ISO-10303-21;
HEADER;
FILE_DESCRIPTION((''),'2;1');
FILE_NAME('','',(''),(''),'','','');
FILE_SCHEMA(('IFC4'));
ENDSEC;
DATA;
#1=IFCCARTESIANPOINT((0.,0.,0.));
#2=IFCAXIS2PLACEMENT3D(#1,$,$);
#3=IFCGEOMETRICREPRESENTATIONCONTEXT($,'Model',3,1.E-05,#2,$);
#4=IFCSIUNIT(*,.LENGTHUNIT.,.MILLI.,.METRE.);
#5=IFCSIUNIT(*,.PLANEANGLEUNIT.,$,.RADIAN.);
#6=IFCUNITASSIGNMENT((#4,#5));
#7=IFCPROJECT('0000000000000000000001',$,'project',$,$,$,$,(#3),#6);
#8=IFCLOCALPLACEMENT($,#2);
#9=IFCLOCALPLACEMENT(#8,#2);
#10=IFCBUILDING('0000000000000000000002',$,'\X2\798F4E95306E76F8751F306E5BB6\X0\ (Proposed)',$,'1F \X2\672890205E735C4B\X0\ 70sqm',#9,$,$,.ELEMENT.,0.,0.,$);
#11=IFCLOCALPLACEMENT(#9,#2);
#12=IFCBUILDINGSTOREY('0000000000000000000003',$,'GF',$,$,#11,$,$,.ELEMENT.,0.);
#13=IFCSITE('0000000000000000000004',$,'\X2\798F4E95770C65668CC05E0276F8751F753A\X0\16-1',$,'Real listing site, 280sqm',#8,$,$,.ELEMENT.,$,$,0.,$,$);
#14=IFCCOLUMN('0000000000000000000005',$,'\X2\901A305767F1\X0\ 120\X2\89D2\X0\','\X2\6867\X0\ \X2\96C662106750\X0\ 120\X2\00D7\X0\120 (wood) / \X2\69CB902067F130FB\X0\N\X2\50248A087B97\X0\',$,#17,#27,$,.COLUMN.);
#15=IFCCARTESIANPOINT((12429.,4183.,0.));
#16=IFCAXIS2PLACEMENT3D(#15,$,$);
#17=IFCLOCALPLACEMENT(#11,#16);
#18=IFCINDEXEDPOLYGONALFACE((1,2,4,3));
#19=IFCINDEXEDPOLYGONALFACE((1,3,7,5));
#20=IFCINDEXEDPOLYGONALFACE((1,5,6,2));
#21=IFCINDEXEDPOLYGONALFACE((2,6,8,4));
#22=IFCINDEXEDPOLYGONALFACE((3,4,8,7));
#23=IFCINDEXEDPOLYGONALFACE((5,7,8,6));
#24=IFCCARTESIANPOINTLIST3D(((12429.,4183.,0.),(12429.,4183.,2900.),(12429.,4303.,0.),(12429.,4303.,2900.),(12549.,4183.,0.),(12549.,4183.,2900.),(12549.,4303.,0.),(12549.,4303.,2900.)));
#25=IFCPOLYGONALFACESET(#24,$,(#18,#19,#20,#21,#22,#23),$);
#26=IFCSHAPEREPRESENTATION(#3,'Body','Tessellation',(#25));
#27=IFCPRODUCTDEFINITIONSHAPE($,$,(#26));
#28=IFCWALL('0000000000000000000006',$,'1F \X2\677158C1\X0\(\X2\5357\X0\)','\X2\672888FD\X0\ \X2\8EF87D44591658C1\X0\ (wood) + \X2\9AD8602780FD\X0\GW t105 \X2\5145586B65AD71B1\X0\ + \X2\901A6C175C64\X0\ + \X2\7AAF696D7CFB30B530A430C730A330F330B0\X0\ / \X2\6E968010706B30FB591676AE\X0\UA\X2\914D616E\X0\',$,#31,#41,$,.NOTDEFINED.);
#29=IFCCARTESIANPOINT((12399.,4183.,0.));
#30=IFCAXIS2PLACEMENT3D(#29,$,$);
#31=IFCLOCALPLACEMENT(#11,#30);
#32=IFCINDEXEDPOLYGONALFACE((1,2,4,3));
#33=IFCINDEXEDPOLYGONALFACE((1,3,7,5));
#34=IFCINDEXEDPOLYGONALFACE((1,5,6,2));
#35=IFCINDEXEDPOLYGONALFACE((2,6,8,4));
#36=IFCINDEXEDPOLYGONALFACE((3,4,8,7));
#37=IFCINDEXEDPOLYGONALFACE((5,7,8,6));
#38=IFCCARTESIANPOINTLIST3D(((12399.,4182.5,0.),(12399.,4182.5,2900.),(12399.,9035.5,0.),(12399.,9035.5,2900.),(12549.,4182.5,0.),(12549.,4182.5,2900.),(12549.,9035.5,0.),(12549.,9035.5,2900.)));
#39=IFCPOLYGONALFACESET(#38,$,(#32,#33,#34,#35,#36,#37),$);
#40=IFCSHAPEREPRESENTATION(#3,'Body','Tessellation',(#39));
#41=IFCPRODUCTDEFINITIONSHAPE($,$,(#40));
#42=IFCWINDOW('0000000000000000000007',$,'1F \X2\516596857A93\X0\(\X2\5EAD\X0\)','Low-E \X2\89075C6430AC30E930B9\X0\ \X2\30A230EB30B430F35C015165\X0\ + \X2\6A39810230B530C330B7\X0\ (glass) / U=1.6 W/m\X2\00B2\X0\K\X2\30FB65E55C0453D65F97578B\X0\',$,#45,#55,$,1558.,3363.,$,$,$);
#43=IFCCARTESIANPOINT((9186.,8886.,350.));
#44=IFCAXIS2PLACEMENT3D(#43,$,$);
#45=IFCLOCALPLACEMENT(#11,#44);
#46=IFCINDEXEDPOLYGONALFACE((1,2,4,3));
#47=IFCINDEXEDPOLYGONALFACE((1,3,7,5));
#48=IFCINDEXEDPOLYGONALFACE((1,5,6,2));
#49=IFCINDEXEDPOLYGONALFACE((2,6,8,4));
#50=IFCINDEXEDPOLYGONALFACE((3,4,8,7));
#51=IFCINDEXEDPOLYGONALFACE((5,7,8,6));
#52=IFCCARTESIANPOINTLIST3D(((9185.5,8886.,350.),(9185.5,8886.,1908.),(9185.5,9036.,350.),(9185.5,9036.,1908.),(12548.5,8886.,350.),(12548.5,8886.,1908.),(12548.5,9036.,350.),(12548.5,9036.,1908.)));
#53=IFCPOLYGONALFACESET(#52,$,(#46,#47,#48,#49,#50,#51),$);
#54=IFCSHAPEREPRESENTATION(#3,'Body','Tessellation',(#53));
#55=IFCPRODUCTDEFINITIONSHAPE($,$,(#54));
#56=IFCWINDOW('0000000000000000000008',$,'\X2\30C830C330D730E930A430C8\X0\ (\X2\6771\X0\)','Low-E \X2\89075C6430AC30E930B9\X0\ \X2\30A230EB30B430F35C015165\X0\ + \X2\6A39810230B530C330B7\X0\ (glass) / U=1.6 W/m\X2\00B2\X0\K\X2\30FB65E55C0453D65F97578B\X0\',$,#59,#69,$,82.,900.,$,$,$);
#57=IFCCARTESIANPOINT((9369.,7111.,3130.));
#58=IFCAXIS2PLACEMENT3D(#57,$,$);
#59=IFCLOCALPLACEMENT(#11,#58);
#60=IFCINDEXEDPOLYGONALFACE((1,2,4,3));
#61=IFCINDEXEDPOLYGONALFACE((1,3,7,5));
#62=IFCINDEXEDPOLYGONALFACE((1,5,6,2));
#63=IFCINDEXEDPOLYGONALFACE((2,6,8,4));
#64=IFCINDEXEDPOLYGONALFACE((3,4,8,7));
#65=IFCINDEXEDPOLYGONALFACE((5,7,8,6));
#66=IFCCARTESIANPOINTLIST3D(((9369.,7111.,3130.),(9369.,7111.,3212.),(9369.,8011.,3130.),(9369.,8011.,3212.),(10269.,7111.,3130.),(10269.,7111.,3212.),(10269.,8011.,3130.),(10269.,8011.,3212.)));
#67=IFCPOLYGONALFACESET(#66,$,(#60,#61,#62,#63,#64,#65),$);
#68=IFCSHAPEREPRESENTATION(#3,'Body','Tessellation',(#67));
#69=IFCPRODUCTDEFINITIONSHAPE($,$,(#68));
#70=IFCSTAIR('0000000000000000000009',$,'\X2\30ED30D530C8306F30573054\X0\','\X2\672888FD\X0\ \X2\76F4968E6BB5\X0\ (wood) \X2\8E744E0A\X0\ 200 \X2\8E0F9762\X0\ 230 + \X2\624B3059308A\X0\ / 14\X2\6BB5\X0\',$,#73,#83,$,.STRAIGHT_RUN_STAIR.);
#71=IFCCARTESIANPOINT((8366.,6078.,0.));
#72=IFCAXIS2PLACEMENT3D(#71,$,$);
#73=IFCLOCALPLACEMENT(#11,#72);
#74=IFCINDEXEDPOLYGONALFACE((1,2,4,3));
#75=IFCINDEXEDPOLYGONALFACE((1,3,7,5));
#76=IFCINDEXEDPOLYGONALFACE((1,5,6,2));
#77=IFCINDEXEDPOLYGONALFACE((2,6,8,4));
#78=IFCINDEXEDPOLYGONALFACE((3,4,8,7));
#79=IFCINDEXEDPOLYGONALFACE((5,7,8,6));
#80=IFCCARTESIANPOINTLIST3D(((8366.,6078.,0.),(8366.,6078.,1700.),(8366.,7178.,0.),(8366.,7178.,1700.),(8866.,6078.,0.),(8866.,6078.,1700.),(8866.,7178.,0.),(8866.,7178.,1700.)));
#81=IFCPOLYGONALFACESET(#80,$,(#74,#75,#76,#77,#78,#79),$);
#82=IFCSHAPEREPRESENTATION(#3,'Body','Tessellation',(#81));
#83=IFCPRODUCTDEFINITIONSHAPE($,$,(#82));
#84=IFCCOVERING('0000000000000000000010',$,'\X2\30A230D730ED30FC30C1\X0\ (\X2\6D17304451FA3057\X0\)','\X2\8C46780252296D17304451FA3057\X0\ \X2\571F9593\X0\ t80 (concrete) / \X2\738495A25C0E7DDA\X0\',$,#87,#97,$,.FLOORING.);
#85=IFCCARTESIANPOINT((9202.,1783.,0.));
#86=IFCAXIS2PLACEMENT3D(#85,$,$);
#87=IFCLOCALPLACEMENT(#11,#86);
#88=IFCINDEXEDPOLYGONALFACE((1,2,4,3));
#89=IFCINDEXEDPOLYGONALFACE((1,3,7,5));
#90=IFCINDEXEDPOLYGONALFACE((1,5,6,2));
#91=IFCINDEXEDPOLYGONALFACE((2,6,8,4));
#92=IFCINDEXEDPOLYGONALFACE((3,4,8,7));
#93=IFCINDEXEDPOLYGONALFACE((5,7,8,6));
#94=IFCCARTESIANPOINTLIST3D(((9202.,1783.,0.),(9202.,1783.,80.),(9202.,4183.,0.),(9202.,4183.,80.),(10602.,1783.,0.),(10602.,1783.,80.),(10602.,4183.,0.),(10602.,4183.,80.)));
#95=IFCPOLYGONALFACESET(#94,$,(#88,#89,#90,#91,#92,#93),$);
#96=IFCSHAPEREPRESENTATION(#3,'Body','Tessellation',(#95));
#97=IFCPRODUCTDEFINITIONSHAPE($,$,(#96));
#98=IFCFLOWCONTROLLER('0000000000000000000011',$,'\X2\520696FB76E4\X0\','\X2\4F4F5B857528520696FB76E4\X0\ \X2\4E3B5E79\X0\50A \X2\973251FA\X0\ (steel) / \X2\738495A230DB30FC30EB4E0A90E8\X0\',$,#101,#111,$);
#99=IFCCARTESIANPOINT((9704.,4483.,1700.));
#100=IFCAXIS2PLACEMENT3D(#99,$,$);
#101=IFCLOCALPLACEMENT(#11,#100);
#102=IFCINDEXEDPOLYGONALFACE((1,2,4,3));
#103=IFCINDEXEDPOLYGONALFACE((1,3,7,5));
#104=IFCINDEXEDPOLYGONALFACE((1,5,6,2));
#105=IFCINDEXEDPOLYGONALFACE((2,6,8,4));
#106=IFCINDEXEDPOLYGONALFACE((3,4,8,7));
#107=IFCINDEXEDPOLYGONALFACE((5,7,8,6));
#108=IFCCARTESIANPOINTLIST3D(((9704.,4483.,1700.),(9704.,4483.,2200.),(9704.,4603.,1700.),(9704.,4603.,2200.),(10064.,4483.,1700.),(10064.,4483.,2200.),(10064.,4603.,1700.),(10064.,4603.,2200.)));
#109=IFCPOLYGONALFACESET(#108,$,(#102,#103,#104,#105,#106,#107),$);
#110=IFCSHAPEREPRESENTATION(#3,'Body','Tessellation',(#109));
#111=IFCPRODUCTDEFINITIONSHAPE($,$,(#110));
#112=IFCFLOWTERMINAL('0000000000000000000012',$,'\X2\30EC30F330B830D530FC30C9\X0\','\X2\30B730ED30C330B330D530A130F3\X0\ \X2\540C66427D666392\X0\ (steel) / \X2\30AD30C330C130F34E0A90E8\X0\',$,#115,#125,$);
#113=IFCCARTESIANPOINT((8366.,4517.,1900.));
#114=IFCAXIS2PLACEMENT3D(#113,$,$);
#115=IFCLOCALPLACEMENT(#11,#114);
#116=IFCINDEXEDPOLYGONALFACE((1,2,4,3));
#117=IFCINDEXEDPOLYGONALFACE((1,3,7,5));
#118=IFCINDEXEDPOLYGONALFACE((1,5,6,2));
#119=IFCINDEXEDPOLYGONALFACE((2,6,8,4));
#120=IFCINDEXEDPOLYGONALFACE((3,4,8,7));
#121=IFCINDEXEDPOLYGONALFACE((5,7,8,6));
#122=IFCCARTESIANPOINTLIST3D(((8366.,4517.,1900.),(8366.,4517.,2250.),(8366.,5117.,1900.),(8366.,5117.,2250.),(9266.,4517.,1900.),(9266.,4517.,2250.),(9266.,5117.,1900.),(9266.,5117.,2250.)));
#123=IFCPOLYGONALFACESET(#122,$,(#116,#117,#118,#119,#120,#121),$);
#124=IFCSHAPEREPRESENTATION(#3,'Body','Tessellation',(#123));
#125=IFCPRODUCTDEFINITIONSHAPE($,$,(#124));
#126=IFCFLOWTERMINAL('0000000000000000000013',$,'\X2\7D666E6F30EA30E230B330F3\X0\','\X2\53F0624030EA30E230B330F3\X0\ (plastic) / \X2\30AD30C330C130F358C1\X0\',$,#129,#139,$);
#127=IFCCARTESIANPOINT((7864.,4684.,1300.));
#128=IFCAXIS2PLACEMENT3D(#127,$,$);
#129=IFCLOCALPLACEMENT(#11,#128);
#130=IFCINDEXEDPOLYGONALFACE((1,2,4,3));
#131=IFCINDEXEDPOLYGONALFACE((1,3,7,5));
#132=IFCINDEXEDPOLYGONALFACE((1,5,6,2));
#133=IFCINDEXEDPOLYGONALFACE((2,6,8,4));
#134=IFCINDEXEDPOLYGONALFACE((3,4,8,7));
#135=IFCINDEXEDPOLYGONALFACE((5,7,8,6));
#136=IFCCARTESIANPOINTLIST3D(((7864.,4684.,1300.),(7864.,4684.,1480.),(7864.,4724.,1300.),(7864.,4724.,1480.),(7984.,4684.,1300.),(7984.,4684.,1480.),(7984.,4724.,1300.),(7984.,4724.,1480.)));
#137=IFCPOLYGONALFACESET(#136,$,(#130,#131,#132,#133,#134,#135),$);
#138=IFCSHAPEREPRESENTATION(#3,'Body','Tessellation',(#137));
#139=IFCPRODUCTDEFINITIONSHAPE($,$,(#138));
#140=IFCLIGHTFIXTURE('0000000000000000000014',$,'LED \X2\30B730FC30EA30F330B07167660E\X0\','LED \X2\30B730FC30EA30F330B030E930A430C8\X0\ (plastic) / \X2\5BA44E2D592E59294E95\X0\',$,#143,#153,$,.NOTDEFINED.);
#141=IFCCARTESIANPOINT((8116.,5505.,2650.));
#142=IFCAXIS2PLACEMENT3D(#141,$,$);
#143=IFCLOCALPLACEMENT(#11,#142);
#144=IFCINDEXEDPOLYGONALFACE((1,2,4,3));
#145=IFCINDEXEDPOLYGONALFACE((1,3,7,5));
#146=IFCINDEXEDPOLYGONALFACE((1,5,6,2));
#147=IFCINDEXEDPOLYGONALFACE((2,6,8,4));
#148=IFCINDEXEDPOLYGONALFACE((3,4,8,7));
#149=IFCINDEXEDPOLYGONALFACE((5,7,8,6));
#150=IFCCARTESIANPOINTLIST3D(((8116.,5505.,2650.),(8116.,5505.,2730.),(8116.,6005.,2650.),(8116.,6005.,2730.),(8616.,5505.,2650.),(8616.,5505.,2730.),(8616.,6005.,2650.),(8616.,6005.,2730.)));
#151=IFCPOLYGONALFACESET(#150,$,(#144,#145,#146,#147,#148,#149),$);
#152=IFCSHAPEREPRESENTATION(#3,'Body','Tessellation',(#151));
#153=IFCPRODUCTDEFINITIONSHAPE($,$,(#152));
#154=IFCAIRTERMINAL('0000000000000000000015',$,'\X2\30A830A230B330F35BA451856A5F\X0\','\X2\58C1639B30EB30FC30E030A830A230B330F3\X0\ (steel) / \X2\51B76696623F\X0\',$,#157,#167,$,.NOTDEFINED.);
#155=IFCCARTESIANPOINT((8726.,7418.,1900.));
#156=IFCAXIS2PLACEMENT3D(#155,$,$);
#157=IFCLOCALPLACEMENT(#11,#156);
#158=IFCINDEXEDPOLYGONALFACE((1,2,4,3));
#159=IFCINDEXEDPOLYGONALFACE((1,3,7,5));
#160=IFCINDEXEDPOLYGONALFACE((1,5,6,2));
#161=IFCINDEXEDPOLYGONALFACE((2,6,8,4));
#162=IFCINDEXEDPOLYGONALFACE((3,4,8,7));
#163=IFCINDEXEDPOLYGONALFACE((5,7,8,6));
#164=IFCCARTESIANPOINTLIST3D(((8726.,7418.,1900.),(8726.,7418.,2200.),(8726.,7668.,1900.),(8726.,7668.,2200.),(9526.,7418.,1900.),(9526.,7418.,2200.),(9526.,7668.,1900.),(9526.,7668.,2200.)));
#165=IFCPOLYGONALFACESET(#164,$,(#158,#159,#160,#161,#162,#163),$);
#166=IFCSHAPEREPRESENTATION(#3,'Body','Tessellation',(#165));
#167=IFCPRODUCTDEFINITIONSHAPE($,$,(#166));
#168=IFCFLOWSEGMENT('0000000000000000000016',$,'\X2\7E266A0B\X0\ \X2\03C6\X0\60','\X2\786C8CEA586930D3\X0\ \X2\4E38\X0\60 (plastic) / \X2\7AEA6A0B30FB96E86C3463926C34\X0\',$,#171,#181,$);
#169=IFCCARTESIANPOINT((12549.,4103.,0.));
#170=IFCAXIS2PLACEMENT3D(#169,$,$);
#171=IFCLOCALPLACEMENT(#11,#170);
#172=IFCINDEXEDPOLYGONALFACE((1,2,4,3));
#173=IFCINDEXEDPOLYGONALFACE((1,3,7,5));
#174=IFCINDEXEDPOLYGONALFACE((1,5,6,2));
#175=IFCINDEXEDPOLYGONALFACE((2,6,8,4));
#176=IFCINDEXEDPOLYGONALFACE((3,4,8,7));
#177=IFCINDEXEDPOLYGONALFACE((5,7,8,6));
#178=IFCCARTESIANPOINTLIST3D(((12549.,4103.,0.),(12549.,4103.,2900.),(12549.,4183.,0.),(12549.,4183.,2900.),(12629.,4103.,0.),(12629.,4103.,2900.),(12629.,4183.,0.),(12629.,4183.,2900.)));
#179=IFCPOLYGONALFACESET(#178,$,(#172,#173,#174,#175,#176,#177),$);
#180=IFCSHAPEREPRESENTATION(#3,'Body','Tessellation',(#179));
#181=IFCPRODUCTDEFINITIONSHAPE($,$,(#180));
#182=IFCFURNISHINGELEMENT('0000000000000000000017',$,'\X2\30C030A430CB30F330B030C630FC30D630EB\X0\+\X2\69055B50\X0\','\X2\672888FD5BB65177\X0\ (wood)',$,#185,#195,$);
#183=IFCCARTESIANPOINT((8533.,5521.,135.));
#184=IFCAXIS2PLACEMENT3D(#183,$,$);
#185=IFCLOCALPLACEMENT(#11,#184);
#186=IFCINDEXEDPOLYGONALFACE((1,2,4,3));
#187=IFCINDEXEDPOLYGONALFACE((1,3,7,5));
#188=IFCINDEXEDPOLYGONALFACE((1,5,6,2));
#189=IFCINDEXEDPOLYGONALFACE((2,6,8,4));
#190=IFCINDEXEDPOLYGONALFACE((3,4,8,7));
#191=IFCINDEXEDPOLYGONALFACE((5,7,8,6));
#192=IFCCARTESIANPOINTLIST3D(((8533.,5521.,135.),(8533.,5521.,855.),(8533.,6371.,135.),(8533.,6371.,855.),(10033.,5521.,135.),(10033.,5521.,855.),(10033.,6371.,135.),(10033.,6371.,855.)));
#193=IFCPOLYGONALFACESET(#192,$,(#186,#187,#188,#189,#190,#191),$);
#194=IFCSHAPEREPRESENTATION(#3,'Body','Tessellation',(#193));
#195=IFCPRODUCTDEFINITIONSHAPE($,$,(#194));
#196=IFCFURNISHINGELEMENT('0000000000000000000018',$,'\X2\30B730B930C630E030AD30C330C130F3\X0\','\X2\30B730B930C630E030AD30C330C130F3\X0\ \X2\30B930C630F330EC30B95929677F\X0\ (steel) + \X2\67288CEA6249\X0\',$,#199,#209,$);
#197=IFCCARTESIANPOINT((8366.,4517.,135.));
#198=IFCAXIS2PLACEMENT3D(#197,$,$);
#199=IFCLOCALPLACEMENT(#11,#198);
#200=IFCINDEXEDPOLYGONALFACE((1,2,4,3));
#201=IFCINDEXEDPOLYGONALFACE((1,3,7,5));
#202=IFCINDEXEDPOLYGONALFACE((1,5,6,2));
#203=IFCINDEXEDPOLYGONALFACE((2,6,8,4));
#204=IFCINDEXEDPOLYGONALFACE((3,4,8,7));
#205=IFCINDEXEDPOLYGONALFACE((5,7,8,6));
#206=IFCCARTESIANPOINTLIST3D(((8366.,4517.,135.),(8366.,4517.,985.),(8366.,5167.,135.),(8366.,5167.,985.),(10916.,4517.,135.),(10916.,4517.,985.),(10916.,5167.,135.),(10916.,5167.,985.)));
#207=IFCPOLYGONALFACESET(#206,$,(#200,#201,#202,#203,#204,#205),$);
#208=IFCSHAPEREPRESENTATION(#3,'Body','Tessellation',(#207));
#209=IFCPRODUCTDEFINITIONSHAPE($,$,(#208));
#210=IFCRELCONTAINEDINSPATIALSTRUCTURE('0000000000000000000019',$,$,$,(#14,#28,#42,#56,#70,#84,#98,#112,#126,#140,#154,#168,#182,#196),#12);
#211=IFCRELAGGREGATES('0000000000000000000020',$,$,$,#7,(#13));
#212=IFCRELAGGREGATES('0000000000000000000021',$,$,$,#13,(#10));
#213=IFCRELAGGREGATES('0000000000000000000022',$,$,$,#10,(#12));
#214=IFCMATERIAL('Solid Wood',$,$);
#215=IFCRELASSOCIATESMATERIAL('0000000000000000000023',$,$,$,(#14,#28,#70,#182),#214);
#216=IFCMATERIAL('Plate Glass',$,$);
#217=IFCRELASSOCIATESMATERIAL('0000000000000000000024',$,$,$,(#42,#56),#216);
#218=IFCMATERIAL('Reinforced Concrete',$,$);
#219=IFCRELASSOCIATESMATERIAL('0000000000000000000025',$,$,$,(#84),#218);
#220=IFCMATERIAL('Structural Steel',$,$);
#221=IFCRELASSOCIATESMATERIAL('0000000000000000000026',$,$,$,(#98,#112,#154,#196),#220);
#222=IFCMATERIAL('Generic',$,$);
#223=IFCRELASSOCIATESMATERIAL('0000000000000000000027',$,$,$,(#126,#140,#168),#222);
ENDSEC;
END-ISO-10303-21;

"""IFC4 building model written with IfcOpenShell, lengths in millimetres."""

from ifc_helpers import new_model, si_unit, frame, frame_2d, origin, place, context, project, spatial, rectangle, extrude, material, element, fill, save


model = new_model("IFC4")

# Units and contexts
model_context = context("Model", 3, precision=1e-05, world=origin())
ifc_project = project(units=[si_unit("LENGTHUNIT", "METRE", prefix="MILLI"), si_unit("PLANEANGLEUNIT", "RADIAN")], contexts=[model_context])

# Site, building, storey
site_placement = place(None, origin())
site = spatial("IfcSite", under=ifc_project, at=site_placement, Name="福井県敦賀市相生町16-1", ObjectType="Real listing site, 280sqm", CompositionType="ELEMENT", RefElevation=0.0)
building_placement = place(site_placement, origin())
building = spatial("IfcBuilding", under=site, at=building_placement, Name="福井の相生の家 (Proposed)", ObjectType="1F 木造平屋 70sqm", CompositionType="ELEMENT", ElevationOfRefHeight=0.0, ElevationOfTerrain=0.0)
storey_placement = place(building_placement, origin())
storey = spatial("IfcBuildingStorey", under=building, at=storey_placement, Name="GF", CompositionType="ELEMENT", Elevation=0.0)

# Column
ifc_material_1 = material(Name="Solid Wood")
column_1_placement = place(storey_placement, frame((12429.0, 4183.0, 0.0)))
element("IfcColumn", 1, at=column_1_placement, inside=storey, material=ifc_material_1, Name="通し柱 120角", Description="桧 集成材 120×120 (wood) / 構造柱・N値計算", PredefinedType="COLUMN", context=model_context, shape_type="SweptSolid", body=[
    extrude(rectangle(XDim=120.0, YDim=120.0, at=frame_2d((60.0, 60.0))), frame((12429.0, 4183.0, 0.0)), (0.0, 0.0, 1.0), 2900.0),
])

# Wall, opening, window
wall_1_placement = place(storey_placement, frame((12399.0, 4183.0, 0.0)))
wall_1 = element("IfcWall", 2, at=wall_1_placement, inside=storey, material=ifc_material_1, Name="1F 東壁(南)", Description="木製 軸組外壁 (wood) + 高性能GW t105 充填断熱 + 通気層 + 窯業系サイディング / 準耐火・外皮UA配慮", PredefinedType="NOTDEFINED", context=model_context, shape_type="SweptSolid", body=[
    extrude(rectangle(XDim=150.0, YDim=4853.0, at=frame_2d((75.0, 2426.0))), frame((12399.0, 4183.0, 0.0)), (0.0, 0.0, 1.0), 2900.0),
])
opening_1_placement = place(storey_placement, frame((9186.0, 8886.0, 350.0)))
opening_1 = element("IfcOpeningElement", 3, at=opening_1_placement, cuts=wall_1, PredefinedType="NOTDEFINED", context=model_context, shape_type="SweptSolid", body=[
    extrude(rectangle(XDim=3363.0, YDim=150.0, at=frame_2d((1681.0, 75.0))), frame((9186.0, 8886.0, 350.0)), (0.0, 0.0, 1.0), 1558.0),
])
ifc_material_2 = material(Name="Plate Glass")
window_1_placement = place(storey_placement, frame((9186.0, 8886.0, 350.0)))
window_1 = element("IfcWindow", 4, at=window_1_placement, inside=storey, material=ifc_material_2, Name="1F 入隅窓(庭)", Description="Low-E 複層ガラス アルゴン封入 + 樹脂サッシ (glass) / U=1.6 W/m²K・日射取得型", OverallHeight=1558.0, OverallWidth=3363.0, context=model_context, shape_type="SweptSolid", body=[
    extrude(rectangle(XDim=3363.0, YDim=150.0, at=frame_2d((1681.0, 75.0))), frame((9186.0, 8886.0, 350.0)), (0.0, 0.0, 1.0), 1558.0),
])
fill(opening_1, window_1)

# Window
window_2_placement = place(storey_placement, frame((9369.0, 7111.0, 3130.0)))
element("IfcWindow", 5, at=window_2_placement, inside=storey, material=ifc_material_2, Name="トップライト (東)", Description="Low-E 複層ガラス アルゴン封入 + 樹脂サッシ (glass) / U=1.6 W/m²K・日射取得型", OverallHeight=82.0, OverallWidth=900.0, context=model_context, shape_type="SweptSolid", body=[
    extrude(rectangle(XDim=900.0, YDim=900.0, at=frame_2d((450.0, 450.0))), frame((9369.0, 7111.0, 3130.0)), (0.0, 0.0, 1.0), 82.0),
])

# Stair
stair_placement = place(storey_placement, frame((8366.0, 6078.0, 0.0)))
element("IfcStair", 6, at=stair_placement, inside=storey, material=ifc_material_1, Name="ロフトはしご", Description="木製 直階段 (wood) 蹴上 200 踏面 230 + 手すり / 14段", PredefinedType="STRAIGHT_RUN_STAIR", context=model_context, shape_type="SweptSolid", body=[
    extrude(rectangle(XDim=500.0, YDim=1100.0, at=frame_2d((250.0, 550.0))), frame((8366.0, 6078.0, 0.0)), (0.0, 0.0, 1.0), 1700.0),
])

# Covering
ifc_material_3 = material(Name="Reinforced Concrete")
covering_placement = place(storey_placement, frame((9202.0, 1783.0, 0.0)))
element("IfcCovering", 7, at=covering_placement, inside=storey, material=ifc_material_3, Name="アプローチ (洗い出し)", Description="豆砂利洗い出し 土間 t80 (concrete) / 玄関導線", PredefinedType="FLOORING", context=model_context, shape_type="SweptSolid", body=[
    extrude(rectangle(XDim=1400.0, YDim=2400.0, at=frame_2d((700.0, 1200.0))), frame((9202.0, 1783.0, 0.0)), (0.0, 0.0, 1.0), 80.0),
])

# Flow controller
ifc_material_4 = material(Name="Structural Steel")
flow_controller_placement = place(storey_placement, frame((9704.0, 4483.0, 1700.0)))
element("IfcFlowController", 8, at=flow_controller_placement, inside=storey, material=ifc_material_4, Name="分電盤", Description="住宅用分電盤 主幹50A 露出 (steel) / 玄関ホール上部", context=model_context, shape_type="SweptSolid", body=[
    extrude(rectangle(XDim=360.0, YDim=120.0, at=frame_2d((180.0, 60.0))), frame((9704.0, 4483.0, 1700.0)), (0.0, 0.0, 1.0), 500.0),
])

# Flow terminals
flow_terminal_1_placement = place(storey_placement, frame((8366.0, 4517.0, 1900.0)))
element("IfcFlowTerminal", 9, at=flow_terminal_1_placement, inside=storey, material=ifc_material_4, Name="レンジフード", Description="シロッコファン 同時給排 (steel) / キッチン上部", context=model_context, shape_type="SweptSolid", body=[
    extrude(rectangle(XDim=900.0, YDim=600.0, at=frame_2d((450.0, 300.0))), frame((8366.0, 4517.0, 1900.0)), (0.0, 0.0, 1.0), 350.0),
])
ifc_material_5 = material(Name="Generic")
flow_terminal_2_placement = place(storey_placement, frame((7864.0, 4684.0, 1300.0)))
element("IfcFlowTerminal", 10, at=flow_terminal_2_placement, inside=storey, material=ifc_material_5, Name="給湯リモコン", Description="台所リモコン (plastic) / キッチン壁", context=model_context, shape_type="SweptSolid", body=[
    extrude(rectangle(XDim=120.0, YDim=40.0, at=frame_2d((60.0, 20.0))), frame((7864.0, 4684.0, 1300.0)), (0.0, 0.0, 1.0), 180.0),
])

# Light fixture
light_fixture_placement = place(storey_placement, frame((8116.0, 5505.0, 2650.0)))
element("IfcLightFixture", 11, at=light_fixture_placement, inside=storey, material=ifc_material_5, Name="LED シーリング照明", Description="LED シーリングライト (plastic) / 室中央天井", PredefinedType="NOTDEFINED", context=model_context, shape_type="SweptSolid", body=[
    extrude(rectangle(XDim=500.0, YDim=500.0, at=frame_2d((250.0, 250.0))), frame((8116.0, 5505.0, 2650.0)), (0.0, 0.0, 1.0), 80.0),
])

# Air terminal
air_terminal_placement = place(storey_placement, frame((8726.0, 7418.0, 1900.0)))
element("IfcAirTerminal", 12, at=air_terminal_placement, inside=storey, material=ifc_material_4, Name="エアコン室内機", Description="壁掛ルームエアコン (steel) / 冷暖房", PredefinedType="NOTDEFINED", context=model_context, shape_type="SweptSolid", body=[
    extrude(rectangle(XDim=800.0, YDim=250.0, at=frame_2d((400.0, 125.0))), frame((8726.0, 7418.0, 1900.0)), (0.0, 0.0, 1.0), 300.0),
])

# Flow segment
flow_segment_placement = place(storey_placement, frame((12549.0, 4103.0, 0.0)))
element("IfcFlowSegment", 13, at=flow_segment_placement, inside=storey, material=ifc_material_5, Name="縦樋 φ60", Description="硬質塩ビ 丸60 (plastic) / 竪樋・雨水排水", context=model_context, shape_type="SweptSolid", body=[
    extrude(rectangle(XDim=80.0, YDim=80.0, at=frame_2d((40.0, 40.0))), frame((12549.0, 4103.0, 0.0)), (0.0, 0.0, 1.0), 2900.0),
])

# Furnishing elements
furnishing_1_placement = place(storey_placement, frame((8533.0, 5521.0, 135.0)))
element("IfcFurnishingElement", 14, at=furnishing_1_placement, inside=storey, material=ifc_material_1, Name="ダイニングテーブル+椅子", Description="木製家具 (wood)", context=model_context, shape_type="SweptSolid", body=[
    extrude(rectangle(XDim=1500.0, YDim=850.0, at=frame_2d((750.0, 425.0))), frame((8533.0, 5521.0, 135.0)), (0.0, 0.0, 1.0), 720.0),
])
furnishing_2_placement = place(storey_placement, frame((8366.0, 4517.0, 135.0)))
element("IfcFurnishingElement", 15, at=furnishing_2_placement, inside=storey, material=ifc_material_4, Name="システムキッチン", Description="システムキッチン ステンレス天板 (steel) + 木質扉", context=model_context, shape_type="SweptSolid", body=[
    extrude(rectangle(XDim=2550.0, YDim=650.0, at=frame_2d((1275.0, 325.0))), frame((8366.0, 4517.0, 135.0)), (0.0, 0.0, 1.0), 850.0),
])

save(model, "model.ifc")
